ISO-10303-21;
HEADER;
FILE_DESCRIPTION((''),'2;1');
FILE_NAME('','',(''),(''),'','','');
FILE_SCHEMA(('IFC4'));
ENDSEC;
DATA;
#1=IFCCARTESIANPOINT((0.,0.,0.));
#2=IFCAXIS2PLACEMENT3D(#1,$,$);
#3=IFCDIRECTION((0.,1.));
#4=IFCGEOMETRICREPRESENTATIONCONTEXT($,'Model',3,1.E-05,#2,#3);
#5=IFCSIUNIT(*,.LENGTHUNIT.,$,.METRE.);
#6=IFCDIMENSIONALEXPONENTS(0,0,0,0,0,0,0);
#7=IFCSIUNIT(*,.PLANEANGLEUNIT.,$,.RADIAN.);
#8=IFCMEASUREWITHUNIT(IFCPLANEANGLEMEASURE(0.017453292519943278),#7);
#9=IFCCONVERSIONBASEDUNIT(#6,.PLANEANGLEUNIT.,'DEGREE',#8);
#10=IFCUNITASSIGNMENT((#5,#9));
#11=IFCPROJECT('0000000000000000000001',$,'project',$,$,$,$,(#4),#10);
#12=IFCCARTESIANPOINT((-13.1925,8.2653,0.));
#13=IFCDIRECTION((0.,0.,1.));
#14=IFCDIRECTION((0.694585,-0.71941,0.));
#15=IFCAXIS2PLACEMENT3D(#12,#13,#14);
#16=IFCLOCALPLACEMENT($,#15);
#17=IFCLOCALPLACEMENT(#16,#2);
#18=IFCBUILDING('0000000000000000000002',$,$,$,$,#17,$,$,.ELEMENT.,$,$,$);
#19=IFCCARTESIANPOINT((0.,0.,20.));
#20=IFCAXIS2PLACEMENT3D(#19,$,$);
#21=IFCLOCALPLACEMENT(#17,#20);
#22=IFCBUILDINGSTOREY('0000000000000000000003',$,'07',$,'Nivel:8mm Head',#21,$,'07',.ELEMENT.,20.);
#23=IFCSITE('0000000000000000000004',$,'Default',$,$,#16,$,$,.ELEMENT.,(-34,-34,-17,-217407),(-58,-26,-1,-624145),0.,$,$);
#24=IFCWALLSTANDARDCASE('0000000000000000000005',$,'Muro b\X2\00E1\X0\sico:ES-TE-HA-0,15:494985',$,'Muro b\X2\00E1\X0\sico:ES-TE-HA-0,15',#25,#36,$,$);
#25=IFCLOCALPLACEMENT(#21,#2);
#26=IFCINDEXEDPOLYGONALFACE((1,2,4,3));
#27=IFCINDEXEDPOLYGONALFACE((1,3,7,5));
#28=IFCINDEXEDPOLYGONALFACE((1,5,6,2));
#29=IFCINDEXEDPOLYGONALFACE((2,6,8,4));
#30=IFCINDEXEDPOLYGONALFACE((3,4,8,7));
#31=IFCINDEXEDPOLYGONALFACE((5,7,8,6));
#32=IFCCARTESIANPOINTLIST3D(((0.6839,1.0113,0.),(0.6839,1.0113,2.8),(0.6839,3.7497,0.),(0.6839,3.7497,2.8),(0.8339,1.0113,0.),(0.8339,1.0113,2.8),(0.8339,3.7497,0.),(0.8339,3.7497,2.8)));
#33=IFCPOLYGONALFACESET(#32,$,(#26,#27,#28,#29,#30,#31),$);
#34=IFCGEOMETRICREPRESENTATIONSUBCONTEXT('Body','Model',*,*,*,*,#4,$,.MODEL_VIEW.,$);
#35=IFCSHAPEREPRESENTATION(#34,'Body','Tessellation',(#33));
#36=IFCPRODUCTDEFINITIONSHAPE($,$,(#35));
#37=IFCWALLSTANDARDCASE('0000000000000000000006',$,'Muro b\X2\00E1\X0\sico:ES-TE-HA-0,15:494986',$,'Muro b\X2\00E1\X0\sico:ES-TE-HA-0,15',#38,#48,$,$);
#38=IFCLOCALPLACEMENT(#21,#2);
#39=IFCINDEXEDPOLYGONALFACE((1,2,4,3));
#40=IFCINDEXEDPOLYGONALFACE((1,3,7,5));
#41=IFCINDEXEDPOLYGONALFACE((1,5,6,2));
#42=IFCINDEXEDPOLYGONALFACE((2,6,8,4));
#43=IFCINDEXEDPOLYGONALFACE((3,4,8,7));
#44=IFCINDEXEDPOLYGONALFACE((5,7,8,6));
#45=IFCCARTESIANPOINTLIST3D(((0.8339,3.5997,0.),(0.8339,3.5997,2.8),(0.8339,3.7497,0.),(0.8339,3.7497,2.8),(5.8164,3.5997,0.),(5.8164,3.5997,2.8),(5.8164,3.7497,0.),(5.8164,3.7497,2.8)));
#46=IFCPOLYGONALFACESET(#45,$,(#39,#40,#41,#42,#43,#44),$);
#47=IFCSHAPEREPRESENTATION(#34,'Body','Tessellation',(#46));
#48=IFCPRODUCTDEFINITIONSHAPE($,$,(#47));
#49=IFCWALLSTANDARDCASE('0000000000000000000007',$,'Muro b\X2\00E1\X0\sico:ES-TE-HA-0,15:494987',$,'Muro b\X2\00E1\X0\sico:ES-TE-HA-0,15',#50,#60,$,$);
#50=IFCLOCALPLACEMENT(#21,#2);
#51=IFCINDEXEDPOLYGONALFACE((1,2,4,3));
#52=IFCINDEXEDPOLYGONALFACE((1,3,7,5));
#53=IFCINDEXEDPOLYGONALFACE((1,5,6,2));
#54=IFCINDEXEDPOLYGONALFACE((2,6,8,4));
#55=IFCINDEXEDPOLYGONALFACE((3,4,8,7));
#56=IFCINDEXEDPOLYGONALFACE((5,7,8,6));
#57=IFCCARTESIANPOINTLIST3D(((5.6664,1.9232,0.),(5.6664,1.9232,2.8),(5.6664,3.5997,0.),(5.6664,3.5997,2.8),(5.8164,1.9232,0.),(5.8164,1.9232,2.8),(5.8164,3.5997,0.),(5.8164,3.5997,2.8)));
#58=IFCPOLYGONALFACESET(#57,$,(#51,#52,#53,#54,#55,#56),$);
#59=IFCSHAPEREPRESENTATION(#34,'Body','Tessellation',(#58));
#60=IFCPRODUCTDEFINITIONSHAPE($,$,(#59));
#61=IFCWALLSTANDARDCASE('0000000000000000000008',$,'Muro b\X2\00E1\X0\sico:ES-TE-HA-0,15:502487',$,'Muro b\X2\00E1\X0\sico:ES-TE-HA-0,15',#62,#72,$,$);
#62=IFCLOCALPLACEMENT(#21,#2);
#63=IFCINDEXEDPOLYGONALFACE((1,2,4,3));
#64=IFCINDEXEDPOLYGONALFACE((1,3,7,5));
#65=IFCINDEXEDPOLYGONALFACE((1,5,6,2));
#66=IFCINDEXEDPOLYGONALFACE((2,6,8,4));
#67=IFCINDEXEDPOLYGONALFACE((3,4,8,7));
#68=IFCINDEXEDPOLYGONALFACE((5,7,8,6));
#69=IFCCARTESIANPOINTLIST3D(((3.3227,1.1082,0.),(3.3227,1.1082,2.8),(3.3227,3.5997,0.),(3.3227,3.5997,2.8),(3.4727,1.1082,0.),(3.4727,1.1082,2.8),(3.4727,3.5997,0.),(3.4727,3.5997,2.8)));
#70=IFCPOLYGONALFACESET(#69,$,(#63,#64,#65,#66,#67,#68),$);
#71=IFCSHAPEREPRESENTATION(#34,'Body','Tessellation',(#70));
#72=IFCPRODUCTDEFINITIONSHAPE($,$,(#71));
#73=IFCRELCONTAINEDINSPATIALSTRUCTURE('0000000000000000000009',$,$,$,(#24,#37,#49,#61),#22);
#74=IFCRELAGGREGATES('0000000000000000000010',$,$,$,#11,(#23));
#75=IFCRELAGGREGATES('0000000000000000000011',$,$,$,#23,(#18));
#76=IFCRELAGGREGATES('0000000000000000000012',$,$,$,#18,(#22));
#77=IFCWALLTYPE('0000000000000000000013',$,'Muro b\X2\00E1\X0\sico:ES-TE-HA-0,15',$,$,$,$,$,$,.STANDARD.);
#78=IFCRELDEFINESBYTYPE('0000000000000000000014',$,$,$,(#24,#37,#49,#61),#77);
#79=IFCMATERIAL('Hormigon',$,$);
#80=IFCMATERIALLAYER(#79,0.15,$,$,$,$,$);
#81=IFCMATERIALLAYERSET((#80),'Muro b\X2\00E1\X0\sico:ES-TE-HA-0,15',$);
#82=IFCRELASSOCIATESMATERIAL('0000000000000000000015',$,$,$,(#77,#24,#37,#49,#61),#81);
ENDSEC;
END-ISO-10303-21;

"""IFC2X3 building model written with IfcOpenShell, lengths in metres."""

from ifc_helpers import new_model, entity, si_unit, converted_unit, direction, frame, frame_2d, origin, place, context, subcontext, project, spatial, rectangle, extrude, material, layer, layer_set, layer_usage, type_object, element, save


model = new_model("IFC2X3")

# Units and contexts
model_context = context("Model", 3, precision=1e-05, world=origin(), true_north=direction((0.0, 1.0)))
body_context = subcontext(model_context, "Body", "Model", "MODEL_VIEW")
ifc_project = project(units=[si_unit("LENGTHUNIT", "METRE"), converted_unit("PLANEANGLEUNIT", "DEGREE", entity("IfcPlaneAngleMeasure", 0.017453292519943278), si_unit("PLANEANGLEUNIT", "RADIAN"), dimensions=[0, 0, 0, 0, 0, 0, 0])], contexts=[model_context])

# Site, building, storey
site_placement = place(None, frame((-13.1925, 8.2653, 0.0), z_axis=(0.0, 0.0, 1.0), x_axis=(0.694585, -0.71941, 0.0)))
site = spatial("IfcSite", under=ifc_project, at=site_placement, Name="Default", CompositionType="ELEMENT", RefLatitude=(-34, -34, -17, -217407), RefLongitude=(-58, -26, -1, -624145), RefElevation=0.0)
building_placement = place(site_placement, origin())
building = spatial("IfcBuilding", under=site, at=building_placement, CompositionType="ELEMENT")
storey_placement = place(building_placement, frame((0.0, 0.0, 20.0)))
storey = spatial("IfcBuildingStorey", under=building, at=storey_placement, Name="07", ObjectType="Nivel:8mm Head", LongName="07", CompositionType="ELEMENT", Elevation=20.0)

# Shared definitions
ifc_material_1 = material(Name="Hormigon")

# Walls
ifc_layer_1 = layer(ifc_material_1, 0.15)
ifc_layer_set_1 = layer_set([ifc_layer_1], Name="Muro básico:ES-TE-HA-0,15")
ifc_layer_usage_1 = layer_usage(ifc_layer_set_1, "AXIS2", "NEGATIVE", 0.075)
wall_type = type_object("IfcWallType", Name="Muro básico:ES-TE-HA-0,15", PredefinedType="STANDARD", material=ifc_layer_set_1)
wall_1_placement = place(storey_placement, frame((0.7589, 1.0113, 0.0), z_axis=(0.0, 0.0, 1.0), x_axis=(0.0, 1.0, 0.0)))
element("IfcWallStandardCase", 1, at=wall_1_placement, inside=storey, type_object=wall_type, material=ifc_layer_usage_1, Name="Muro básico:ES-TE-HA-0,15:494985", ObjectType="Muro básico:ES-TE-HA-0,15", context=body_context, shape_type="SweptSolid", body=[
    extrude(rectangle(XDim=2.7384, YDim=0.15, at=frame_2d((1.3692, 0.0), x_axis=(-1.0, 0.0))), origin(), (0.0, 0.0, 1.0), 2.8),
])
ifc_layer_usage_2 = layer_usage(ifc_layer_set_1, "AXIS2", "NEGATIVE", 0.075)
wall_2_placement = place(storey_placement, frame((0.8339, 3.6747, 0.0)))
element("IfcWallStandardCase", 2, at=wall_2_placement, inside=storey, type_object=wall_type, material=ifc_layer_usage_2, Name="Muro básico:ES-TE-HA-0,15:494986", ObjectType="Muro básico:ES-TE-HA-0,15", context=body_context, shape_type="SweptSolid", body=[
    extrude(rectangle(XDim=4.9825, YDim=0.15, at=frame_2d((2.4912, 0.0), x_axis=(-1.0, 0.0))), origin(), (0.0, 0.0, 1.0), 2.8),
])
ifc_layer_usage_3 = layer_usage(ifc_layer_set_1, "AXIS2", "NEGATIVE", 0.075)
wall_3_placement = place(storey_placement, frame((5.7414, 1.9232, 0.0), z_axis=(0.0, 0.0, 1.0), x_axis=(0.0, 1.0, 0.0)))
element("IfcWallStandardCase", 3, at=wall_3_placement, inside=storey, type_object=wall_type, material=ifc_layer_usage_3, Name="Muro básico:ES-TE-HA-0,15:494987", ObjectType="Muro básico:ES-TE-HA-0,15", context=body_context, shape_type="SweptSolid", body=[
    extrude(rectangle(XDim=1.6765, YDim=0.15, at=frame_2d((0.8382, 0.0), x_axis=(-1.0, 0.0))), origin(), (0.0, 0.0, 1.0), 2.8),
])
ifc_layer_usage_4 = layer_usage(ifc_layer_set_1, "AXIS2", "NEGATIVE", 0.075)
wall_4_placement = place(storey_placement, frame((3.3977, 3.5997, 0.0), z_axis=(0.0, 0.0, 1.0), x_axis=(0.0, -1.0, 0.0)))
element("IfcWallStandardCase", 4, at=wall_4_placement, inside=storey, type_object=wall_type, material=ifc_layer_usage_4, Name="Muro básico:ES-TE-HA-0,15:502487", ObjectType="Muro básico:ES-TE-HA-0,15", context=body_context, shape_type="SweptSolid", body=[
    extrude(rectangle(XDim=2.4915, YDim=0.15, at=frame_2d((1.2457, 0.0), x_axis=(-1.0, 0.0))), origin(), (0.0, 0.0, 1.0), 2.8),
])

save(model, "model.ifc")
